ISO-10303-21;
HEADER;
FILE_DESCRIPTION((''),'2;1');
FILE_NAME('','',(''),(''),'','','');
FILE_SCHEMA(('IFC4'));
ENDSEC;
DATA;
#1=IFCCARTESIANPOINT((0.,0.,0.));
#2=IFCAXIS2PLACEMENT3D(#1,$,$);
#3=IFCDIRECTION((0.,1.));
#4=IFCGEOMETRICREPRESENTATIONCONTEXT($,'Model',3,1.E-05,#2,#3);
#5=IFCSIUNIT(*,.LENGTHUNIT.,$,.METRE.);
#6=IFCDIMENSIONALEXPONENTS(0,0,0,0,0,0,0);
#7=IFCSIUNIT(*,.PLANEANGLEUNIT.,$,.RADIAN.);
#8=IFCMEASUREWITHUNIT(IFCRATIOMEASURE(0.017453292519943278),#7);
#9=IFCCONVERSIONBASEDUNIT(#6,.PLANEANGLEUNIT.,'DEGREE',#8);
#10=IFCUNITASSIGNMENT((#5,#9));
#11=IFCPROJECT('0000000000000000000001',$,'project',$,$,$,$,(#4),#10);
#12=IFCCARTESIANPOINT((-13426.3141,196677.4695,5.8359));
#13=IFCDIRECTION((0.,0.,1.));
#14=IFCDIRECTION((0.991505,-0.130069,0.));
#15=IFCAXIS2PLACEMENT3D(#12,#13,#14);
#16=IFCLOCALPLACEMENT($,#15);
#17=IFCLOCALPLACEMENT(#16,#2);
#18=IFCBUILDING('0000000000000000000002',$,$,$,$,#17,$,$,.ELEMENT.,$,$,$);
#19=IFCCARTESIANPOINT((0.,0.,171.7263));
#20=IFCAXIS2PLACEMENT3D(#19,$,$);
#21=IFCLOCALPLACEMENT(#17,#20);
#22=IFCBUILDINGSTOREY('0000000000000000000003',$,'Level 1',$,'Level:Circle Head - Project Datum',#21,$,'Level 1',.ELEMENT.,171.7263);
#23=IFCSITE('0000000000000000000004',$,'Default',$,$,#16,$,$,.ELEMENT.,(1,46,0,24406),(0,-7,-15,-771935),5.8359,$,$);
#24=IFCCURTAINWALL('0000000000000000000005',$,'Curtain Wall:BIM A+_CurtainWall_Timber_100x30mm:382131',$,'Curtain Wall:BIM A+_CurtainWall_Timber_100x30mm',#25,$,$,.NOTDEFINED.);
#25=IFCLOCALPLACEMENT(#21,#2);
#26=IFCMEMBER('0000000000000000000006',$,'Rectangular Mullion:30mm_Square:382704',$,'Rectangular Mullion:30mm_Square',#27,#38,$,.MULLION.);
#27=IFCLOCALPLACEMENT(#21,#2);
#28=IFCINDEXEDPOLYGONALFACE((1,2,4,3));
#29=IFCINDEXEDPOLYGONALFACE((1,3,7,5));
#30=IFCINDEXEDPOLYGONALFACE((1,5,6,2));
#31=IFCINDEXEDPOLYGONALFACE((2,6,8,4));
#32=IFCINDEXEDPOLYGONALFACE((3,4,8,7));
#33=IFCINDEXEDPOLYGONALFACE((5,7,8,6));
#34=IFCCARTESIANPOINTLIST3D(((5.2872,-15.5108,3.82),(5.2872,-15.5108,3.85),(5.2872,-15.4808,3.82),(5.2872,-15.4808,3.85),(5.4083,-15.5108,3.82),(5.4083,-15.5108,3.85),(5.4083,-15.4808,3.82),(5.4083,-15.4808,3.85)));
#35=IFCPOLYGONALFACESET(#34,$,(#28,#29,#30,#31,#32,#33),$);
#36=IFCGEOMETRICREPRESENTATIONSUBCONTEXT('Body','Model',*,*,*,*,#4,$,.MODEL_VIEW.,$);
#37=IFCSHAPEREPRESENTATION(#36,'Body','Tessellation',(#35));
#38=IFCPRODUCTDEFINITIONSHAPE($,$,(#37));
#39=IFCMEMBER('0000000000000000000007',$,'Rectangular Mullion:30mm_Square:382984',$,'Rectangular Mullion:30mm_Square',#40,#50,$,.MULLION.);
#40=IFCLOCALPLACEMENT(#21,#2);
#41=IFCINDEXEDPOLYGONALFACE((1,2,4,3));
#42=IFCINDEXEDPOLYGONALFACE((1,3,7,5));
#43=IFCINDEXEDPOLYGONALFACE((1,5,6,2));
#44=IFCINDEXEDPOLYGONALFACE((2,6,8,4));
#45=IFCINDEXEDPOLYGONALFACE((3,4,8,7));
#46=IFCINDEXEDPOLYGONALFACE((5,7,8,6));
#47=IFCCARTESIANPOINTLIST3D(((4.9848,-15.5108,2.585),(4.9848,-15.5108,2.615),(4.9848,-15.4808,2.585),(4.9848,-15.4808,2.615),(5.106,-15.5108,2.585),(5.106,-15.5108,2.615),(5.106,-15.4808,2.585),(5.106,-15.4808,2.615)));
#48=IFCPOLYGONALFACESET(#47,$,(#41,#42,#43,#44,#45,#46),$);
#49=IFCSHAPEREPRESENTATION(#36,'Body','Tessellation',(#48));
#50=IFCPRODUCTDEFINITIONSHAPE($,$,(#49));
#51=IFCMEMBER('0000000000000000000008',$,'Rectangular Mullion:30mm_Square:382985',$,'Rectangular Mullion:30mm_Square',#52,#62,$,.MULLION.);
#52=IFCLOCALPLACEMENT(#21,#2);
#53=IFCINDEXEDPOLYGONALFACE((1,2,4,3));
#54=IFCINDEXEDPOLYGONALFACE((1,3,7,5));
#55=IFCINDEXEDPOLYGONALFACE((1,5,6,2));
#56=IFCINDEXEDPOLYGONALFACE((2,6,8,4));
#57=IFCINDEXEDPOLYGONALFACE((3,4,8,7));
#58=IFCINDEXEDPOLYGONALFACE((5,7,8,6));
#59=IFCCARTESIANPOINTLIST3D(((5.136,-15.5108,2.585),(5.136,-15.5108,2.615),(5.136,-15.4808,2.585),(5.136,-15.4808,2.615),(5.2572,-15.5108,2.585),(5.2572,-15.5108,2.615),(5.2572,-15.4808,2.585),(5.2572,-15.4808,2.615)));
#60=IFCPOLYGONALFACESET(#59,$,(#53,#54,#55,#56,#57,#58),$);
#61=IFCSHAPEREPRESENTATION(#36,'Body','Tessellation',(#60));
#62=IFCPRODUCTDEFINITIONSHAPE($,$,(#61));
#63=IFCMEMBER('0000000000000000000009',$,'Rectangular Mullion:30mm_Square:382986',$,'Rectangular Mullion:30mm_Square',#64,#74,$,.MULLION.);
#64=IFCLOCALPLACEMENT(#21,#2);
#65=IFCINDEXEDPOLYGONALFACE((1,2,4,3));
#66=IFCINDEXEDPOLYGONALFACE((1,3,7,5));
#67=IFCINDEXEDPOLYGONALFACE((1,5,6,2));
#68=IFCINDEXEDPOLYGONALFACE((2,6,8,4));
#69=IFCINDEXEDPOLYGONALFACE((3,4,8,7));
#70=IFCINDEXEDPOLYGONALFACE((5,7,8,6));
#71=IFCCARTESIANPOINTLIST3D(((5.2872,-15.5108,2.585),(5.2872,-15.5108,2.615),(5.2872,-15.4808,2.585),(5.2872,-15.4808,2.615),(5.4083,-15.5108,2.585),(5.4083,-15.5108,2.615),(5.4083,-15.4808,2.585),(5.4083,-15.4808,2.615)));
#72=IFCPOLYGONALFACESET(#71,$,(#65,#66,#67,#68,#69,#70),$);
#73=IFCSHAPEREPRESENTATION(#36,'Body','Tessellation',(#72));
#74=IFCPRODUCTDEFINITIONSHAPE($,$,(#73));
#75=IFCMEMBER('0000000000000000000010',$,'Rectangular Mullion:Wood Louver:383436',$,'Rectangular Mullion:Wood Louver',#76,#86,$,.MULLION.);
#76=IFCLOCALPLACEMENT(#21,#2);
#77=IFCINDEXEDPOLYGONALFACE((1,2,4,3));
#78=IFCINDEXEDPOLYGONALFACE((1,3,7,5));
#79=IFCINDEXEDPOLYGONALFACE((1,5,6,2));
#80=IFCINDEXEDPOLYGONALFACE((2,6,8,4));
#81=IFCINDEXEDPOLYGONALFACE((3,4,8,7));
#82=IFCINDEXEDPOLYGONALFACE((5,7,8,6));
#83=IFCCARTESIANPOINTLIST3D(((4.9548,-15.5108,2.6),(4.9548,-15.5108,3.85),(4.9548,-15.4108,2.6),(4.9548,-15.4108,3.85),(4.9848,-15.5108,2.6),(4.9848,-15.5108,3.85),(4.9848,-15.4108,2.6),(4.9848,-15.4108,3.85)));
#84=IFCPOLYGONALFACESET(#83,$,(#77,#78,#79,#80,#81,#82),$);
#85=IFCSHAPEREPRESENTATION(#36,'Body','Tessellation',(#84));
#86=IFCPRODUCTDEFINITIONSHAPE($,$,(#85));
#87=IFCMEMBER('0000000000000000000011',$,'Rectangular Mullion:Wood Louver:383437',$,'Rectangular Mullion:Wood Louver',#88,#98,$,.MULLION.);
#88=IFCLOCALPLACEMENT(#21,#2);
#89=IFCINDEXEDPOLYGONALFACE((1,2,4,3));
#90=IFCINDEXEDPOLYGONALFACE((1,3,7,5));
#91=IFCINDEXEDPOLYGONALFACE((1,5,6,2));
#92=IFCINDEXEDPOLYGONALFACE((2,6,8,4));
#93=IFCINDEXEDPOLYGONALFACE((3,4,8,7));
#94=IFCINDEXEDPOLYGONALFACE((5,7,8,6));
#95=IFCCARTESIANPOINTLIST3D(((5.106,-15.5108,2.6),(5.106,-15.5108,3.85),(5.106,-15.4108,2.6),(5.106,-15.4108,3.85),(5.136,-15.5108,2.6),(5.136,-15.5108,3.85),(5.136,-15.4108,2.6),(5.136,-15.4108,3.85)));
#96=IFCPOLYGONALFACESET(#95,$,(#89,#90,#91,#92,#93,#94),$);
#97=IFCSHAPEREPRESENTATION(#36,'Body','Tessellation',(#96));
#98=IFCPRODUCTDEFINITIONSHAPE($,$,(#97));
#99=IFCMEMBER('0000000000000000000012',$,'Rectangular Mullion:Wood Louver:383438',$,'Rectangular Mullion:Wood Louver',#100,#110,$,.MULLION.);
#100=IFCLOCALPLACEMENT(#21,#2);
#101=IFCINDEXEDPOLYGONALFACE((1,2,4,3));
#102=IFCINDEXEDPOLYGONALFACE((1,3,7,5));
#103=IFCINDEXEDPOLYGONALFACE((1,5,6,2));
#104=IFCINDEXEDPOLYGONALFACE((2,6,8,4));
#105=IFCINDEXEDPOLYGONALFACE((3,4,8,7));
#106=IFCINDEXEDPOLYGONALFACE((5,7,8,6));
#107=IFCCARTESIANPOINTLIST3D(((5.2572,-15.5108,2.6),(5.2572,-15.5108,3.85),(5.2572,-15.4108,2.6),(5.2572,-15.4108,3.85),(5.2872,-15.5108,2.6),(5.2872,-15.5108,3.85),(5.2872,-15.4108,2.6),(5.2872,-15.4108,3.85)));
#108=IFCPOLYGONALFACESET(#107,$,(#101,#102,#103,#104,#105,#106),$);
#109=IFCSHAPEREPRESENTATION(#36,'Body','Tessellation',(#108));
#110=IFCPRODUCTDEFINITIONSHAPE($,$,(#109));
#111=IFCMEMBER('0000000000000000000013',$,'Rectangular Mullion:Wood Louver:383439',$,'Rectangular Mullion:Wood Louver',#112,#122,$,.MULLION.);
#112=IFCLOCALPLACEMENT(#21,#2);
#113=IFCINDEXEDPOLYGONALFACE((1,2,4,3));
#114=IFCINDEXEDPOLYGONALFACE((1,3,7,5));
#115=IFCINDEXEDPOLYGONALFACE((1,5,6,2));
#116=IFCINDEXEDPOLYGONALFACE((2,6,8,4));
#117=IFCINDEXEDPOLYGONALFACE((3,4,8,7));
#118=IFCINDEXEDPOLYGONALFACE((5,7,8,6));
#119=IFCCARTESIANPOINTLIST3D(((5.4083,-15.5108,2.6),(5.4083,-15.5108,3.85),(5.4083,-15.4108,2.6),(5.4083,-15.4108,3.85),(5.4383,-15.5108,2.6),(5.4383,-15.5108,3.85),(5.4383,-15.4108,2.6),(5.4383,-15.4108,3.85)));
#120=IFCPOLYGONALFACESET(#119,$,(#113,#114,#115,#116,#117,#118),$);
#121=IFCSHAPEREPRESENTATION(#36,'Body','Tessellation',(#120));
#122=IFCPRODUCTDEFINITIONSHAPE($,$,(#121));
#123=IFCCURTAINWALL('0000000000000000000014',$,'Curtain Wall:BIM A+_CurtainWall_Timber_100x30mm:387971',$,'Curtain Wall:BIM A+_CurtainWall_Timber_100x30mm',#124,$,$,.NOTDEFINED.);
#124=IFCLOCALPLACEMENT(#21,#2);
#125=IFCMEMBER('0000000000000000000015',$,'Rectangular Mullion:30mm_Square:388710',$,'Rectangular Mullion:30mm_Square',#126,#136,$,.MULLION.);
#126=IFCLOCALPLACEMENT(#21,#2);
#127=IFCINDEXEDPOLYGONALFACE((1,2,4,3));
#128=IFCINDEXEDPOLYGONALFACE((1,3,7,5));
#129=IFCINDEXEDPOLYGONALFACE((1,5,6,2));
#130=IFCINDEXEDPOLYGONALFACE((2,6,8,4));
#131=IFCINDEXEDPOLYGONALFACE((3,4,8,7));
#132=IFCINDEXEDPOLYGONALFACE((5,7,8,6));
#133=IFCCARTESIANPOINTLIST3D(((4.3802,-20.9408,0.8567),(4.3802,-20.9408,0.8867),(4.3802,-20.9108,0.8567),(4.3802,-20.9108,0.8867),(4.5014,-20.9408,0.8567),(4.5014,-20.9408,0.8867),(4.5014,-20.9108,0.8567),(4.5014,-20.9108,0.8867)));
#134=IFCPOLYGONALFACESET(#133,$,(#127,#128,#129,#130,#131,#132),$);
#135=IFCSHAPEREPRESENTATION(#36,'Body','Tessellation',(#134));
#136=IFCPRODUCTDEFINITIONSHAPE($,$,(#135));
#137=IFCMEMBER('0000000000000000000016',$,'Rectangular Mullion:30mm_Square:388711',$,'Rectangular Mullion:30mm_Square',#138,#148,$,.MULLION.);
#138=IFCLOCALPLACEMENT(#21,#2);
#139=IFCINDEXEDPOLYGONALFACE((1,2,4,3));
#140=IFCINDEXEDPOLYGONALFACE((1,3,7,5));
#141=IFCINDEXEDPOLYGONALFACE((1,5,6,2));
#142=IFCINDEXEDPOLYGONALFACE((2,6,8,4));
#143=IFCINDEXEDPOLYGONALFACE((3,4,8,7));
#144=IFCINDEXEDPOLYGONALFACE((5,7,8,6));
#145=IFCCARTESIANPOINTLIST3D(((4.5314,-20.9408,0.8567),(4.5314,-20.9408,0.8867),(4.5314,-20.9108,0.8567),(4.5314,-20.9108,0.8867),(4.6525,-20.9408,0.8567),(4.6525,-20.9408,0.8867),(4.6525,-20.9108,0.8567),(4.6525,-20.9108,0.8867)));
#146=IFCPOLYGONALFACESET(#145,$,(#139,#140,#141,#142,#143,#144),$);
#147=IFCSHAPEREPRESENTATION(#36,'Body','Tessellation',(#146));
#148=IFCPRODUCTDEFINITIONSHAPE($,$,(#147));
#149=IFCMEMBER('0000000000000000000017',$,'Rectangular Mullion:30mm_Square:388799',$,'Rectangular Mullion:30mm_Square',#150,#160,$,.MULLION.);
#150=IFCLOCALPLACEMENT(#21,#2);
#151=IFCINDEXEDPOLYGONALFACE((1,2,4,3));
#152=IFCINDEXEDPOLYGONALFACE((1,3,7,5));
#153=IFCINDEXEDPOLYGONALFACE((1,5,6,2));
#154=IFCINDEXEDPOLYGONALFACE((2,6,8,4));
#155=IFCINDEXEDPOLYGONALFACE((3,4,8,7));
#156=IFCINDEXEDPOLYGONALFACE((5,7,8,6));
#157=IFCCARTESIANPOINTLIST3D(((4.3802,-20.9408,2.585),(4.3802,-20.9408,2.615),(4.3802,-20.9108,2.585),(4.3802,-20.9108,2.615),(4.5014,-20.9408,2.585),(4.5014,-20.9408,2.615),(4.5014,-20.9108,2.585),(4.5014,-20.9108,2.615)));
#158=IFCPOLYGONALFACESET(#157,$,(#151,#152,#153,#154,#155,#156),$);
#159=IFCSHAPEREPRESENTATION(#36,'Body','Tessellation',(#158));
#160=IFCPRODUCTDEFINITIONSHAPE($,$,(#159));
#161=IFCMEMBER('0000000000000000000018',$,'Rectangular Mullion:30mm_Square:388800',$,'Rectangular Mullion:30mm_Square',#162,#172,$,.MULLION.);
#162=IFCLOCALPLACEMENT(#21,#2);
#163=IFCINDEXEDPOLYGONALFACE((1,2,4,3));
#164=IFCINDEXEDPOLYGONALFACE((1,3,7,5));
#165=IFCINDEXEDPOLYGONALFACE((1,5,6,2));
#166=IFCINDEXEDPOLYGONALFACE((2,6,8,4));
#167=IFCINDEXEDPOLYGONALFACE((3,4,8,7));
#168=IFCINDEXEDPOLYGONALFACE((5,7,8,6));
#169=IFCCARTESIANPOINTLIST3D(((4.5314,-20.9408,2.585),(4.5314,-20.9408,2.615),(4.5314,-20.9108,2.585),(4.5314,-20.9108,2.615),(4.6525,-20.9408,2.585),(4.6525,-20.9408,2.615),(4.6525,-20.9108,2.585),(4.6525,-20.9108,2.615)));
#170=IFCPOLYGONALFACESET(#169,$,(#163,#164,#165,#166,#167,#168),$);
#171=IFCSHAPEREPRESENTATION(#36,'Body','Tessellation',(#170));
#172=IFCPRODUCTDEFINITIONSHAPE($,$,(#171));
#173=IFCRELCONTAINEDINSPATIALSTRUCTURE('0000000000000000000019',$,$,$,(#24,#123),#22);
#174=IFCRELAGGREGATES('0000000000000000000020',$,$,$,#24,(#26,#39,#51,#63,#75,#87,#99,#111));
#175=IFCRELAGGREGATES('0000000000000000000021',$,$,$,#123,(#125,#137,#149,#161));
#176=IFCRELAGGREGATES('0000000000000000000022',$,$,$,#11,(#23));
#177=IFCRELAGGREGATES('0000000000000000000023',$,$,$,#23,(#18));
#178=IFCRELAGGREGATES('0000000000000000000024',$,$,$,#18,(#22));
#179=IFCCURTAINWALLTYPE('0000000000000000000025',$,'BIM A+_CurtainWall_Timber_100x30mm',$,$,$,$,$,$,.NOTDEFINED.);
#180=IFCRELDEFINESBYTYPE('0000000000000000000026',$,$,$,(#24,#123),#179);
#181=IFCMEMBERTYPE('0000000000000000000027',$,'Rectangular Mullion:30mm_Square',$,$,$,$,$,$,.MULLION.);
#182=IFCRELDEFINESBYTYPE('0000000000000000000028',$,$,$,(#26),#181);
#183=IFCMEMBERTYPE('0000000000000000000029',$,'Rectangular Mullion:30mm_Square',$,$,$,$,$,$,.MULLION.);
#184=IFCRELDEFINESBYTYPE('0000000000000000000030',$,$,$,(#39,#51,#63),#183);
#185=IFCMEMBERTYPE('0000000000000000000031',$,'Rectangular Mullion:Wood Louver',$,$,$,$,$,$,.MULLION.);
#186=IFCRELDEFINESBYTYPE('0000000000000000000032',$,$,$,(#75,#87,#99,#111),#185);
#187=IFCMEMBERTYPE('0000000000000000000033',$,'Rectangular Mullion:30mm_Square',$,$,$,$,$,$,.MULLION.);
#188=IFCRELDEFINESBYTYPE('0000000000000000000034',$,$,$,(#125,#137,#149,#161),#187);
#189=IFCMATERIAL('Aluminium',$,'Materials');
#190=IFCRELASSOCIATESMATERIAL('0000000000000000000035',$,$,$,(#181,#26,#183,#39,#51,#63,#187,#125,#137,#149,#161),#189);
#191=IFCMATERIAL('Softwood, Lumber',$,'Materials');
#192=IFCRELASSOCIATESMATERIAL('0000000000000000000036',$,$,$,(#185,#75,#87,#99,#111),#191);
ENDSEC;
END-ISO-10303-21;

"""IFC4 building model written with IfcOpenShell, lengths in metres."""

from ifc_helpers import new_model, entity, si_unit, converted_unit, direction, frame, origin, place, context, subcontext, project, spatial, indexed_curve, outline, extrude, source, transform, mapped, material, type_object, type_shapes, element, aggregate, save


model = new_model("IFC4")

# Units and contexts
model_context = context("Model", 3, precision=1e-05, world=origin(), true_north=direction((0.0, 1.0)))
body_context = subcontext(model_context, "Body", "Model", "MODEL_VIEW")
ifc_project = project(units=[si_unit("LENGTHUNIT", "METRE"), converted_unit("PLANEANGLEUNIT", "DEGREE", entity("IfcRatioMeasure", 0.017453292519943278), si_unit("PLANEANGLEUNIT", "RADIAN"), dimensions=[0, 0, 0, 0, 0, 0, 0])], contexts=[model_context])

# Site, building, storey
site_placement = place(None, frame((-13426.3141, 196677.4695, 5.8359), z_axis=(0.0, 0.0, 1.0), x_axis=(0.991505, -0.130069, 0.0)))
site = spatial("IfcSite", under=ifc_project, at=site_placement, Name="Default", CompositionType="ELEMENT", RefLatitude=(1, 46, 0, 24406), RefLongitude=(0, -7, -15, -771935), RefElevation=5.8359)
building_placement = place(site_placement, origin())
building = spatial("IfcBuilding", under=site, at=building_placement, CompositionType="ELEMENT")
storey_placement = place(building_placement, frame((0.0, 0.0, 171.7263)))
storey = spatial("IfcBuildingStorey", under=building, at=storey_placement, Name="Level 1", ObjectType="Level:Circle Head - Project Datum", LongName="Level 1", CompositionType="ELEMENT", Elevation=171.7263)

# Curtain walls, members
ifc_material_1 = material(Name="Aluminium", Category="Materials")
curtain_wall_type_1 = type_object("IfcCurtainWallType", Name="BIM A+_CurtainWall_Timber_100x30mm", PredefinedType="NOTDEFINED")
curtain_wall_1_placement = place(storey_placement, frame((0.0, 0.0, -171.7263)))
curtain_wall_1 = element("IfcCurtainWall", 1, at=curtain_wall_1_placement, inside=storey, type_object=curtain_wall_type_1, Name="Curtain Wall:BIM A+_CurtainWall_Timber_100x30mm:382131", ObjectType="Curtain Wall:BIM A+_CurtainWall_Timber_100x30mm", PredefinedType="NOTDEFINED")
member_type_1 = type_object("IfcMemberType", Name="Rectangular Mullion:30mm_Square", PredefinedType="MULLION", material=ifc_material_1)
shared_shape_1 = source(origin(), body_context, "Body", "SweptSolid", [
    extrude(outline(indexed_curve([(-0.015, -0.015), (0.015, -0.015), (0.015, 0.015), (-0.015, 0.015), (-0.015, -0.015)], self_intersect=False)), frame((-0.015, 0.0, -0.1212), z_axis=(0.0, 0.0, 1.0), x_axis=(0.0, -1.0, 0.0)), (0.0, 0.0, 1.0), 0.1212),
])
type_shapes(member_type_1, [shared_shape_1])
member_1_placement = place(curtain_wall_1_placement, frame((5.4083, -15.4958, 175.5763), z_axis=(1.0, 0.0, 0.0), x_axis=(0.0, 0.0, 1.0)))
member_1 = element("IfcMember", 2, at=member_1_placement, type_object=member_type_1, material=ifc_material_1, Name="Rectangular Mullion:30mm_Square:382704", ObjectType="Rectangular Mullion:30mm_Square", PredefinedType="MULLION", context=body_context, shape_type="MappedRepresentation", body=[
    mapped(shared_shape_1, transform((0.0, 0.0, 0.0), scale=1.0)),
])
member_type_2 = type_object("IfcMemberType", Name="Rectangular Mullion:30mm_Square", PredefinedType="MULLION", material=ifc_material_1)
shared_shape_2 = source(origin(), body_context, "Body", "SweptSolid", [
    extrude(outline(indexed_curve([(-0.015, -0.015), (0.015, -0.015), (0.015, 0.015), (-0.015, 0.015), (-0.015, -0.015)], self_intersect=False)), frame((0.0, 0.0, -0.1212), z_axis=(0.0, 0.0, 1.0), x_axis=(0.0, -1.0, 0.0)), (0.0, 0.0, 1.0), 0.1212),
])
type_shapes(member_type_2, [shared_shape_2])
member_2_placement = place(curtain_wall_1_placement, frame((5.106, -15.4958, 174.3263), z_axis=(1.0, 0.0, 0.0), x_axis=(0.0, 0.0, 1.0)))
member_2 = element("IfcMember", 3, at=member_2_placement, type_object=member_type_2, material=ifc_material_1, Name="Rectangular Mullion:30mm_Square:382984", ObjectType="Rectangular Mullion:30mm_Square", PredefinedType="MULLION", context=body_context, shape_type="MappedRepresentation", body=[
    mapped(shared_shape_2, transform((0.0, 0.0, 0.0), scale=1.0)),
])
member_3_placement = place(curtain_wall_1_placement, frame((5.2572, -15.4958, 174.3263), z_axis=(1.0, 0.0, 0.0), x_axis=(0.0, 0.0, 1.0)))
member_3 = element("IfcMember", 4, at=member_3_placement, type_object=member_type_2, material=ifc_material_1, Name="Rectangular Mullion:30mm_Square:382985", ObjectType="Rectangular Mullion:30mm_Square", PredefinedType="MULLION", context=body_context, shape_type="MappedRepresentation", body=[
    mapped(shared_shape_2, transform((0.0, 0.0, 0.0), scale=1.0)),
])
member_4_placement = place(curtain_wall_1_placement, frame((5.4083, -15.4958, 174.3263), z_axis=(1.0, 0.0, 0.0), x_axis=(0.0, 0.0, 1.0)))
member_4 = element("IfcMember", 5, at=member_4_placement, type_object=member_type_2, material=ifc_material_1, Name="Rectangular Mullion:30mm_Square:382986", ObjectType="Rectangular Mullion:30mm_Square", PredefinedType="MULLION", context=body_context, shape_type="MappedRepresentation", body=[
    mapped(shared_shape_2, transform((0.0, 0.0, 0.0), scale=1.0)),
])
ifc_material_2 = material(Name="Softwood, Lumber", Category="Materials")
member_type_3 = type_object("IfcMemberType", Name="Rectangular Mullion:Wood Louver", PredefinedType="MULLION", material=ifc_material_2)
shared_shape_3 = source(origin(), body_context, "Body", "SweptSolid", [
    extrude(outline(indexed_curve([(-0.05, -0.015), (0.05, -0.015), (0.05, 0.015), (-0.05, 0.015), (-0.05, -0.015)], self_intersect=False)), frame((0.0, -0.035, -1.25), z_axis=(0.0, 0.0, 1.0), x_axis=(0.0, -1.0, 0.0)), (0.0, 0.0, 1.0), 1.25),
])
type_shapes(member_type_3, [shared_shape_3])
member_5_placement = place(curtain_wall_1_placement, frame((4.9698, -15.4958, 174.3263), z_axis=(0.0, 0.0, -1.0), x_axis=(1.0, 0.0, 0.0)))
member_5 = element("IfcMember", 6, at=member_5_placement, type_object=member_type_3, material=ifc_material_2, Name="Rectangular Mullion:Wood Louver:383436", ObjectType="Rectangular Mullion:Wood Louver", PredefinedType="MULLION", context=body_context, shape_type="MappedRepresentation", body=[
    mapped(shared_shape_3, transform((0.0, 0.0, 0.0), scale=1.0)),
])
member_6_placement = place(curtain_wall_1_placement, frame((5.121, -15.4958, 174.3263), z_axis=(0.0, 0.0, -1.0), x_axis=(1.0, 0.0, 0.0)))
member_6 = element("IfcMember", 7, at=member_6_placement, type_object=member_type_3, material=ifc_material_2, Name="Rectangular Mullion:Wood Louver:383437", ObjectType="Rectangular Mullion:Wood Louver", PredefinedType="MULLION", context=body_context, shape_type="MappedRepresentation", body=[
    mapped(shared_shape_3, transform((0.0, 0.0, 0.0), scale=1.0)),
])
member_7_placement = place(curtain_wall_1_placement, frame((5.2722, -15.4958, 174.3263), z_axis=(0.0, 0.0, -1.0), x_axis=(1.0, 0.0, 0.0)))
member_7 = element("IfcMember", 8, at=member_7_placement, type_object=member_type_3, material=ifc_material_2, Name="Rectangular Mullion:Wood Louver:383438", ObjectType="Rectangular Mullion:Wood Louver", PredefinedType="MULLION", context=body_context, shape_type="MappedRepresentation", body=[
    mapped(shared_shape_3, transform((0.0, 0.0, 0.0), scale=1.0)),
])
member_8_placement = place(curtain_wall_1_placement, frame((5.4233, -15.4958, 174.3263), z_axis=(0.0, 0.0, -1.0), x_axis=(1.0, 0.0, 0.0)))
member_8 = element("IfcMember", 9, at=member_8_placement, type_object=member_type_3, material=ifc_material_2, Name="Rectangular Mullion:Wood Louver:383439", ObjectType="Rectangular Mullion:Wood Louver", PredefinedType="MULLION", context=body_context, shape_type="MappedRepresentation", body=[
    mapped(shared_shape_3, transform((0.0, 0.0, 0.0), scale=1.0)),
])
curtain_wall_2_placement = place(storey_placement, frame((0.0, 0.0, -171.7263)))
curtain_wall_2 = element("IfcCurtainWall", 10, at=curtain_wall_2_placement, inside=storey, type_object=curtain_wall_type_1, Name="Curtain Wall:BIM A+_CurtainWall_Timber_100x30mm:387971", ObjectType="Curtain Wall:BIM A+_CurtainWall_Timber_100x30mm", PredefinedType="NOTDEFINED")
member_type_4 = type_object("IfcMemberType", Name="Rectangular Mullion:30mm_Square", PredefinedType="MULLION", material=ifc_material_1)
shared_shape_4 = source(origin(), body_context, "Body", "SweptSolid", [
    extrude(outline(indexed_curve([(-0.015, -0.015), (0.015, -0.015), (0.015, 0.015), (-0.015, 0.015), (-0.015, -0.015)], self_intersect=False)), frame((0.0, 0.0, -0.1212), z_axis=(0.0, 0.0, 1.0), x_axis=(0.0, -1.0, 0.0)), (0.0, 0.0, 1.0), 0.1212),
])
type_shapes(member_type_4, [shared_shape_4])
member_9_placement = place(curtain_wall_2_placement, frame((4.5014, -20.9258, 172.598), z_axis=(1.0, 0.0, 0.0), x_axis=(0.0, 0.0, 1.0)))
member_9 = element("IfcMember", 11, at=member_9_placement, type_object=member_type_4, material=ifc_material_1, Name="Rectangular Mullion:30mm_Square:388710", ObjectType="Rectangular Mullion:30mm_Square", PredefinedType="MULLION", context=body_context, shape_type="MappedRepresentation", body=[
    mapped(shared_shape_4, transform((0.0, 0.0, 0.0), scale=1.0)),
])
member_10_placement = place(curtain_wall_2_placement, frame((4.6525, -20.9258, 172.598), z_axis=(1.0, 0.0, 0.0), x_axis=(0.0, 0.0, 1.0)))
member_10 = element("IfcMember", 12, at=member_10_placement, type_object=member_type_4, material=ifc_material_1, Name="Rectangular Mullion:30mm_Square:388711", ObjectType="Rectangular Mullion:30mm_Square", PredefinedType="MULLION", context=body_context, shape_type="MappedRepresentation", body=[
    mapped(shared_shape_4, transform((0.0, 0.0, 0.0), scale=1.0)),
])
member_11_placement = place(curtain_wall_2_placement, frame((4.5014, -20.9258, 174.3263), z_axis=(1.0, 0.0, 0.0), x_axis=(0.0, 0.0, 1.0)))
member_11 = element("IfcMember", 13, at=member_11_placement, type_object=member_type_4, material=ifc_material_1, Name="Rectangular Mullion:30mm_Square:388799", ObjectType="Rectangular Mullion:30mm_Square", PredefinedType="MULLION", context=body_context, shape_type="MappedRepresentation", body=[
    mapped(shared_shape_4, transform((0.0, 0.0, 0.0), scale=1.0)),
])
member_12_placement = place(curtain_wall_2_placement, frame((4.6525, -20.9258, 174.3263), z_axis=(1.0, 0.0, 0.0), x_axis=(0.0, 0.0, 1.0)))
member_12 = element("IfcMember", 14, at=member_12_placement, type_object=member_type_4, material=ifc_material_1, Name="Rectangular Mullion:30mm_Square:388800", ObjectType="Rectangular Mullion:30mm_Square", PredefinedType="MULLION", context=body_context, shape_type="MappedRepresentation", body=[
    mapped(shared_shape_4, transform((0.0, 0.0, 0.0), scale=1.0)),
])

aggregate(curtain_wall_1, [member_1, member_2, member_3, member_4, member_5, member_6, member_7, member_8])
aggregate(curtain_wall_2, [member_9, member_10, member_11, member_12])

save(model, "model.ifc")
